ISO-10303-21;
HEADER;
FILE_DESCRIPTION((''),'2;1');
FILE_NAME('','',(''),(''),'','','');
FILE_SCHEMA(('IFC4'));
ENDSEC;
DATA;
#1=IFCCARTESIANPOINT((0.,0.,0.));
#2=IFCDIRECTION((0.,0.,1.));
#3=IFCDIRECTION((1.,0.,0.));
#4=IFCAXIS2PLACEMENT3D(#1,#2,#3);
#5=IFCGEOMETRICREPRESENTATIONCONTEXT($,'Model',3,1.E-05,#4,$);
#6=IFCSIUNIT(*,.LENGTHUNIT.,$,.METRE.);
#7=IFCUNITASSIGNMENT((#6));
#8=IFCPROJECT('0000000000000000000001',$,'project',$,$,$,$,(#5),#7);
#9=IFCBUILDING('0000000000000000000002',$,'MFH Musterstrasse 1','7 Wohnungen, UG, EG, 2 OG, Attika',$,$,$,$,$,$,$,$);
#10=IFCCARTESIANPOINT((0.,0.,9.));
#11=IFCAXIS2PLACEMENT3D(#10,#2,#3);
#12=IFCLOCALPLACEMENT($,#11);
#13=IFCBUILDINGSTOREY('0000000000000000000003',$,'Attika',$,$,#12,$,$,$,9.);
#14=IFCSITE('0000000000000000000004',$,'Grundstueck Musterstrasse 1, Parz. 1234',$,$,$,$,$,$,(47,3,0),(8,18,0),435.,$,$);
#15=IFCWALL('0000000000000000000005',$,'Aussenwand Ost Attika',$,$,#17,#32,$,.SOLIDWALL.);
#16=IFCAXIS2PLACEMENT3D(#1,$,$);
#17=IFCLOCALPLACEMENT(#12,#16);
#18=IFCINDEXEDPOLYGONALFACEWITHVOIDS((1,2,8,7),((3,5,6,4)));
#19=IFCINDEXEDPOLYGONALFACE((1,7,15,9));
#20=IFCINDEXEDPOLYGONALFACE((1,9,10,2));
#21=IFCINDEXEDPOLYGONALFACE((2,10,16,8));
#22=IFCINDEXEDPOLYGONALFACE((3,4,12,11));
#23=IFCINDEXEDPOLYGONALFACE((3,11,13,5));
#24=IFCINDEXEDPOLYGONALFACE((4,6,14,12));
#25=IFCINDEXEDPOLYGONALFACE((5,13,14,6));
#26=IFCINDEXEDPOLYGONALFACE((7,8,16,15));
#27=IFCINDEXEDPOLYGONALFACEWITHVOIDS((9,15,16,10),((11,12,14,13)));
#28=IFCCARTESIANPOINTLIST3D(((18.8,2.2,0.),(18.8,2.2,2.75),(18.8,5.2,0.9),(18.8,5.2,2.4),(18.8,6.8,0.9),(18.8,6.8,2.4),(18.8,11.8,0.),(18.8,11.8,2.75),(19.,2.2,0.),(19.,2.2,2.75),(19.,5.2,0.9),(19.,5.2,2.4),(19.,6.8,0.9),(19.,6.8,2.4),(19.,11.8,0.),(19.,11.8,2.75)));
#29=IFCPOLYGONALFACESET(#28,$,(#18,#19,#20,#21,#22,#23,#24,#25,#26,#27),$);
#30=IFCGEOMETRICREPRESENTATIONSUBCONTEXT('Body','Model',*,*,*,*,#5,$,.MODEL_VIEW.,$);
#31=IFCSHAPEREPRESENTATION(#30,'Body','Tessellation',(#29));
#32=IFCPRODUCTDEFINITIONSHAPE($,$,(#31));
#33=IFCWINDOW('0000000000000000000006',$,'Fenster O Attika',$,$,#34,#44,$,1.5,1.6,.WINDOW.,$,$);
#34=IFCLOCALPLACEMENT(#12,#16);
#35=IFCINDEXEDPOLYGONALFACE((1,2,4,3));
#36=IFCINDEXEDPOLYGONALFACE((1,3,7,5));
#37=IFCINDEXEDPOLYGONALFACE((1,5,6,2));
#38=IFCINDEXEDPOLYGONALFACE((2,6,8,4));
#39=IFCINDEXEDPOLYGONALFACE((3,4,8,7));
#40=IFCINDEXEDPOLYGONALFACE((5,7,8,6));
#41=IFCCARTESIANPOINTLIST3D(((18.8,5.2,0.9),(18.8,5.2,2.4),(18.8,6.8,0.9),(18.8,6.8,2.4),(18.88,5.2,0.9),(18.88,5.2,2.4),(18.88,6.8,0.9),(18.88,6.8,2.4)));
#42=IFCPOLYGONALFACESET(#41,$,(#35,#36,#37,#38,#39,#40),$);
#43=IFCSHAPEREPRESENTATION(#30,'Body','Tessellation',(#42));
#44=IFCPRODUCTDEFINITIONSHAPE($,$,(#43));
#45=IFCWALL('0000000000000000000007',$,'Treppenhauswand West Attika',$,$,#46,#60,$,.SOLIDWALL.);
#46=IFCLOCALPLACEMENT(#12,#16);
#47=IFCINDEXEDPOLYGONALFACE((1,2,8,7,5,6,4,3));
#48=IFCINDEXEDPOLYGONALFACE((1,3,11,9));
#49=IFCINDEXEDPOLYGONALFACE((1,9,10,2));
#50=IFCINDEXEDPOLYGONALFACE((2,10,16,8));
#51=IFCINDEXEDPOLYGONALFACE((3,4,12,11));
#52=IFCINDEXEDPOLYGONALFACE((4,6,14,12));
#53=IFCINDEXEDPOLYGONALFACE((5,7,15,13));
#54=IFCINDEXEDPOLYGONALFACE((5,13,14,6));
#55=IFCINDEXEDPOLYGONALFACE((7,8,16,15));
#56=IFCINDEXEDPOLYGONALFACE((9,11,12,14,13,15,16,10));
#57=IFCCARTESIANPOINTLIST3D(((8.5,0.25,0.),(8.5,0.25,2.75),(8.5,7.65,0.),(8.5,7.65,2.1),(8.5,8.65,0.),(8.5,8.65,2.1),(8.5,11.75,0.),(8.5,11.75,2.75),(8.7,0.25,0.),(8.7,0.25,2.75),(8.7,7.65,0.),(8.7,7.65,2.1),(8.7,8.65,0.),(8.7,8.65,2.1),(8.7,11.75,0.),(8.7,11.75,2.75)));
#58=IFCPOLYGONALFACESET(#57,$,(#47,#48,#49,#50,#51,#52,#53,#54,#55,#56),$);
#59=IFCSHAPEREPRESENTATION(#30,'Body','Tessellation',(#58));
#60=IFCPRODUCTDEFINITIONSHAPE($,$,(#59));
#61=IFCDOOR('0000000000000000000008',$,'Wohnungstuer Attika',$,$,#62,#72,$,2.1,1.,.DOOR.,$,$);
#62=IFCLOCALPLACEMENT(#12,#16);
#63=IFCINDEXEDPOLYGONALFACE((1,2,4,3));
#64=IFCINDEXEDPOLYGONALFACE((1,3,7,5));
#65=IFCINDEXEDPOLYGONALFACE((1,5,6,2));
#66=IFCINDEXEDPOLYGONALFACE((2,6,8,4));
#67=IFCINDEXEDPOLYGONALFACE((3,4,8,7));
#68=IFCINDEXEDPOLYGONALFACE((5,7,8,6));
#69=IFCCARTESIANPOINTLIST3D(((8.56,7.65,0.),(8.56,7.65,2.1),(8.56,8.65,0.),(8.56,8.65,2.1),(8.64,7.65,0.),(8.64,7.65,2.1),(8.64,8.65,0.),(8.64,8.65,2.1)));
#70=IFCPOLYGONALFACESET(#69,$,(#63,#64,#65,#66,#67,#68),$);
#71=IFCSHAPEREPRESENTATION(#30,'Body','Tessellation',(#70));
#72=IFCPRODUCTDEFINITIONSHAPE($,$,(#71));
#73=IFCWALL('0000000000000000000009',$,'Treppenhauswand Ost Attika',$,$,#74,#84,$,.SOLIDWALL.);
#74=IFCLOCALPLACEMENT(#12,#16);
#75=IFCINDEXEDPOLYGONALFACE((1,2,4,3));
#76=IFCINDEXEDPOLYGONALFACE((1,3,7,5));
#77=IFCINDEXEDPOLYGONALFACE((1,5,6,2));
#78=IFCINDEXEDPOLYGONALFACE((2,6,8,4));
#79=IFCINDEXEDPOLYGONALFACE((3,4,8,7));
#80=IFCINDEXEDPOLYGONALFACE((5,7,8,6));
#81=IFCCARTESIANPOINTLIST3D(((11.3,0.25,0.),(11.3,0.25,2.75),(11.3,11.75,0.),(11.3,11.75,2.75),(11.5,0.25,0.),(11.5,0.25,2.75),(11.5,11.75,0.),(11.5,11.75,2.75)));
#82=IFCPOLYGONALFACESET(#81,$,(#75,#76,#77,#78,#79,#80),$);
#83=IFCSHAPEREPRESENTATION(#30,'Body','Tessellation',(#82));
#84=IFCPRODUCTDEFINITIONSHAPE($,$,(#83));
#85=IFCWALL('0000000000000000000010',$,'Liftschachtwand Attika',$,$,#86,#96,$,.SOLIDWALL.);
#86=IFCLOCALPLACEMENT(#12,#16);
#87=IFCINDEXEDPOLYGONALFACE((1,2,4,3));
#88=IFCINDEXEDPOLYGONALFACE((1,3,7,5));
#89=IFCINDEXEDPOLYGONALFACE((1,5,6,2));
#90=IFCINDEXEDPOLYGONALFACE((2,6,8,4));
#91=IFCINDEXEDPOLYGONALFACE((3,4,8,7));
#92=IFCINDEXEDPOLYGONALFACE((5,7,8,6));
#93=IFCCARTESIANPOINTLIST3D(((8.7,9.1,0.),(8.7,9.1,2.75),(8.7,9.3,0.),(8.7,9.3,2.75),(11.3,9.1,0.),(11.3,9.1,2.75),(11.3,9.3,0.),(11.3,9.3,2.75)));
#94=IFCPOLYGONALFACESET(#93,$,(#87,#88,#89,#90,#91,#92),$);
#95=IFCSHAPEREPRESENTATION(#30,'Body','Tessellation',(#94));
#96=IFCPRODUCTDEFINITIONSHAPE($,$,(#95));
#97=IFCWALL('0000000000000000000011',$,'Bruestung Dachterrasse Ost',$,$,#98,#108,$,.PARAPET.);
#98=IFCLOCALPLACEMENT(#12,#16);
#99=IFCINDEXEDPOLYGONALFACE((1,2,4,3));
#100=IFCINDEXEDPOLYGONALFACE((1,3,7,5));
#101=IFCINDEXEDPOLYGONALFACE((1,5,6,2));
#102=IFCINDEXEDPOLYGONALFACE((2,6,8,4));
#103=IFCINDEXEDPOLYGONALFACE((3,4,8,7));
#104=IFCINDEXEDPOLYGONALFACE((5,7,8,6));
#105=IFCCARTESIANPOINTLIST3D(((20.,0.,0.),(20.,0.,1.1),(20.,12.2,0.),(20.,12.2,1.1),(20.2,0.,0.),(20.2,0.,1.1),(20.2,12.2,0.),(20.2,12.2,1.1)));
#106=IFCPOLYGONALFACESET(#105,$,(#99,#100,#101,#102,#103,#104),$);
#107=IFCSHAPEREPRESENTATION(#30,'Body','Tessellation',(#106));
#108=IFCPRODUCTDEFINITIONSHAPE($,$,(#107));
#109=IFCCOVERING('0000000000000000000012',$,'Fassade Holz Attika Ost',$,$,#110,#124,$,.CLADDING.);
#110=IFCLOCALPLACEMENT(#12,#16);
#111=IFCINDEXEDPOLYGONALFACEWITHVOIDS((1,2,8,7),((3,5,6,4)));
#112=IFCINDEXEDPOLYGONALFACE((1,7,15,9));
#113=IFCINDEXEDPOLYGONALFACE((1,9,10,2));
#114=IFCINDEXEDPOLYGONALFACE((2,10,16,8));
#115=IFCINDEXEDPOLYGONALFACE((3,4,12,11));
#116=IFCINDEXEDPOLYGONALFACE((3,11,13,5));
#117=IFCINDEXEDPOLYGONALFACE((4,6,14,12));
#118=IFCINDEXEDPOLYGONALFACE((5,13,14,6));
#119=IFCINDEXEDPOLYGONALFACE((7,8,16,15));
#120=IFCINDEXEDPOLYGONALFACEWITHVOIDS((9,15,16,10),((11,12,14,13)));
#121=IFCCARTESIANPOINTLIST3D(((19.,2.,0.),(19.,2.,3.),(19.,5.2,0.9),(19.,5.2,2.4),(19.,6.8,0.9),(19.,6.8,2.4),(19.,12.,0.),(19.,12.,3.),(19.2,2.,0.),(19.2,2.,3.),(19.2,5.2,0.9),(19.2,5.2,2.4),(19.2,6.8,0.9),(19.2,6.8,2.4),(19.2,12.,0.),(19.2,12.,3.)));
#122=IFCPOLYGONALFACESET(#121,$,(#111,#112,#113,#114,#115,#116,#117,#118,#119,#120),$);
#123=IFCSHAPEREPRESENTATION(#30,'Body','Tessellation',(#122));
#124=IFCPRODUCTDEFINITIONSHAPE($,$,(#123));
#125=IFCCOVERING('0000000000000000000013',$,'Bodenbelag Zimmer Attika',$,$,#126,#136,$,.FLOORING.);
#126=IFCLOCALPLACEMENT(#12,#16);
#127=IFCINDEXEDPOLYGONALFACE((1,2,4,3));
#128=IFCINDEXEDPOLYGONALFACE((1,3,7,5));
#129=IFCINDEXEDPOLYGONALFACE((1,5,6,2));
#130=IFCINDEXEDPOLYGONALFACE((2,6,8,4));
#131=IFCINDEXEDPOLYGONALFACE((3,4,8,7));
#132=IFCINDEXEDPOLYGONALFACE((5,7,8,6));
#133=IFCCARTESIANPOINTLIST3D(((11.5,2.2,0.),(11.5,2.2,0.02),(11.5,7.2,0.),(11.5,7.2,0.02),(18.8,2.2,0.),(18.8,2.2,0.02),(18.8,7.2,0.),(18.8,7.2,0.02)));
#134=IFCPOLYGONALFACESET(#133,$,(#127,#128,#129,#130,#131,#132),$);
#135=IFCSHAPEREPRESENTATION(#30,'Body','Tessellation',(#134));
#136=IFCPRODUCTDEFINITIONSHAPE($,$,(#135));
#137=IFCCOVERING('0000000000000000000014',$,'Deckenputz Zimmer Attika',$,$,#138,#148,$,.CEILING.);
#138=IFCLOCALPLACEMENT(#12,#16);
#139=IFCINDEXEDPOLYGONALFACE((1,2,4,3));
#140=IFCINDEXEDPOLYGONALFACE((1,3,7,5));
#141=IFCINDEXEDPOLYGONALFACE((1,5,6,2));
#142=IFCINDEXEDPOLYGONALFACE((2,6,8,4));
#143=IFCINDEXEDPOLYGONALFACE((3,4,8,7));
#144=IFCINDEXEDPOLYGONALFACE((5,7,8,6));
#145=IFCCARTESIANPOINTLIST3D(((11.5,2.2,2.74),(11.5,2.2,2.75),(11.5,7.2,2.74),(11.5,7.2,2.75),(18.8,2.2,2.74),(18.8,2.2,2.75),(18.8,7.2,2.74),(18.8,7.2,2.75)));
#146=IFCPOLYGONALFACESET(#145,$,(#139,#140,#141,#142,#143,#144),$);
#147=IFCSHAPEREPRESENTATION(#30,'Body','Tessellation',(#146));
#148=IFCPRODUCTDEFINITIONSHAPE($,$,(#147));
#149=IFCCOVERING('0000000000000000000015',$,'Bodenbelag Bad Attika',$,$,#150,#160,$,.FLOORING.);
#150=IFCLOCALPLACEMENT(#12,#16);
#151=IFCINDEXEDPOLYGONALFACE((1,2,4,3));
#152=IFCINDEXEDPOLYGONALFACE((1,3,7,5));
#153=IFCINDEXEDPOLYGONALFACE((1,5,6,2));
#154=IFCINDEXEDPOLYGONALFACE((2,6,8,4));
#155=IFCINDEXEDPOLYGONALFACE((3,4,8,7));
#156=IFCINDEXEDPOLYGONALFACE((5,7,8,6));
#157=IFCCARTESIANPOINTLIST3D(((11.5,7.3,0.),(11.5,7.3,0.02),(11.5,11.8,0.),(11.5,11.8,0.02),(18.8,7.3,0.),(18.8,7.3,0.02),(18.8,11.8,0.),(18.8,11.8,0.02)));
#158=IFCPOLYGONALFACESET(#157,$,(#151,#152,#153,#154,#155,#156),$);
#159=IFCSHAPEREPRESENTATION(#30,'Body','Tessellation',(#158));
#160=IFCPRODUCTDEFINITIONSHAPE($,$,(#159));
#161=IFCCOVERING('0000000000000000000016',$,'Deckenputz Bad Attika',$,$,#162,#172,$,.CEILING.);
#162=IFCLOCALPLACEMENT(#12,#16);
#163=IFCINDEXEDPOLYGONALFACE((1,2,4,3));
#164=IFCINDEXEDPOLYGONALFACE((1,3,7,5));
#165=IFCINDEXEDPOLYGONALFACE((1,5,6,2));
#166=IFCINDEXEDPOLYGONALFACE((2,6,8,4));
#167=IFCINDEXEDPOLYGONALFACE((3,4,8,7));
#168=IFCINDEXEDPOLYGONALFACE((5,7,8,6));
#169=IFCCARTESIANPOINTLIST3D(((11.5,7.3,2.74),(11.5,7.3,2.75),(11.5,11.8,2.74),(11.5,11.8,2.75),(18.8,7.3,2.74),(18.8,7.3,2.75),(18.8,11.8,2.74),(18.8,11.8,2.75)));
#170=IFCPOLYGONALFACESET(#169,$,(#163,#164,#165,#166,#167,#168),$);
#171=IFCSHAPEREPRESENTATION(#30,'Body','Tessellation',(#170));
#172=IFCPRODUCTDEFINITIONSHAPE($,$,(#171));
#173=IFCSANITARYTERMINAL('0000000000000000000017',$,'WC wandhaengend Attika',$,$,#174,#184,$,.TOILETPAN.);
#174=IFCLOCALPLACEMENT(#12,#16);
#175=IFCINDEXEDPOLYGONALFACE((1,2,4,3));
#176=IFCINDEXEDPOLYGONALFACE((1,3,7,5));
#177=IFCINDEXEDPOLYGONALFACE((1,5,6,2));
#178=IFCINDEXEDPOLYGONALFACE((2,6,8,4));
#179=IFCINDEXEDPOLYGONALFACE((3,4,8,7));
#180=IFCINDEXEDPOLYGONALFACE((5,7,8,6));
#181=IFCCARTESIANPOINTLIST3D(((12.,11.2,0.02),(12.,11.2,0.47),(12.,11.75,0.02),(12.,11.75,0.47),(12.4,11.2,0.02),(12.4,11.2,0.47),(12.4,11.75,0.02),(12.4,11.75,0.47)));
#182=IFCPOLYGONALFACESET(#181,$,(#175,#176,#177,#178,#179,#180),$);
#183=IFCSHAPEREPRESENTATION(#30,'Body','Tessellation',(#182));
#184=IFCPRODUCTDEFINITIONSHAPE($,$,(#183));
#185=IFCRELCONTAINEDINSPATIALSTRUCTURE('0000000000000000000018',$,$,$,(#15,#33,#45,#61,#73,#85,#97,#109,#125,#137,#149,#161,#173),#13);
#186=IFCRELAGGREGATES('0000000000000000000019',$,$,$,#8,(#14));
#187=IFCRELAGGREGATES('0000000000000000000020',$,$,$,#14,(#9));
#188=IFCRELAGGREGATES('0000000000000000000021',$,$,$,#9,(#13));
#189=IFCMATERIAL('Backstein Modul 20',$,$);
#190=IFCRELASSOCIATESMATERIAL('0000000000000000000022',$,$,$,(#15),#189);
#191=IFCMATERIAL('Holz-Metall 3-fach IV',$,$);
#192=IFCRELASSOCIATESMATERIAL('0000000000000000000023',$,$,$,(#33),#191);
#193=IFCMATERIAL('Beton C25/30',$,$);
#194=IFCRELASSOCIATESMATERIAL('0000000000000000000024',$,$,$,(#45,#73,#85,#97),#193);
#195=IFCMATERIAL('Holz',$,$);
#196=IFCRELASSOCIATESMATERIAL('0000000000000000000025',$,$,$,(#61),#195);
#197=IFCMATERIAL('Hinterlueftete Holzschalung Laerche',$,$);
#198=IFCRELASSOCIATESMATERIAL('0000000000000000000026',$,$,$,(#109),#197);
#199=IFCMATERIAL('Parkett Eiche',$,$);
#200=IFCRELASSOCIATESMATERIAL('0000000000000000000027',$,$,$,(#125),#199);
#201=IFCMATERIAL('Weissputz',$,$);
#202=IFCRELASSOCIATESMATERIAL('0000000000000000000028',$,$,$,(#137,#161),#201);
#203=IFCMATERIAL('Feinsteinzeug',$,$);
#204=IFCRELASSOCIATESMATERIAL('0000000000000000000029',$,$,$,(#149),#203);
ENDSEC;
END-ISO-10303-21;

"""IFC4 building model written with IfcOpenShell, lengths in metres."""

from ifc_helpers import new_model, si_unit, frame, frame_2d, origin_with_axes, place, context, subcontext, project, spatial, rectangle, extrude, material, element, fill, save


model = new_model("IFC4")

# Units and contexts
model_context = context("Model", 3, precision=1e-05, world=origin_with_axes())
body_context = subcontext(model_context, "Body", "Model", "MODEL_VIEW")
ifc_project = project(units=[si_unit("LENGTHUNIT", "METRE")], contexts=[model_context])

# Site, building, storey
site = spatial("IfcSite", under=ifc_project, Name="Grundstueck Musterstrasse 1, Parz. 1234", RefLatitude=(47, 3, 0), RefLongitude=(8, 18, 0), RefElevation=435.0)
building = spatial("IfcBuilding", under=site, Name="MFH Musterstrasse 1", Description="7 Wohnungen, UG, EG, 2 OG, Attika")
storey_placement = place(None, frame((0.0, 0.0, 9.0), z_axis=(0.0, 0.0, 1.0), x_axis=(1.0, 0.0, 0.0)))
storey = spatial("IfcBuildingStorey", under=building, at=storey_placement, Name="Attika", Elevation=9.0)

# Wall, opening, window
ifc_material_1 = material(Name="Backstein Modul 20")
wall_1_placement = place(storey_placement, frame((18.8, 2.2, 0.0), z_axis=(0.0, 0.0, 1.0), x_axis=(1.0, 0.0, 0.0)))
wall_1 = element("IfcWall", 1, at=wall_1_placement, inside=storey, material=ifc_material_1, Name="Aussenwand Ost Attika", PredefinedType="SOLIDWALL", context=body_context, shape_type="SweptSolid", body=[
    extrude(rectangle(XDim=0.2, YDim=9.6, at=frame_2d((0.1, 4.8))), origin_with_axes(), (0.0, 0.0, 1.0), 2.75),
])
opening_1_placement = place(wall_1_placement, frame((-0.01, 3.0, 0.9), z_axis=(0.0, 0.0, 1.0), x_axis=(1.0, 0.0, 0.0)))
opening_1 = element("IfcOpeningElement", 2, at=opening_1_placement, cuts=wall_1, context=body_context, shape_type="SweptSolid", body=[
    extrude(rectangle(XDim=0.42, YDim=1.6, at=frame_2d((0.21, 0.8))), origin_with_axes(), (0.0, 0.0, 1.0), 1.5),
])
ifc_material_2 = material(Name="Holz-Metall 3-fach IV")
window_placement = place(storey_placement, frame((18.8, 5.2, 0.9), z_axis=(0.0, 0.0, 1.0), x_axis=(1.0, 0.0, 0.0)))
window = element("IfcWindow", 3, at=window_placement, inside=storey, material=ifc_material_2, Name="Fenster O Attika", OverallHeight=1.5, OverallWidth=1.6, PredefinedType="WINDOW", context=body_context, shape_type="SweptSolid", body=[
    extrude(rectangle(XDim=0.08, YDim=1.6, at=frame_2d((0.04, 0.8))), origin_with_axes(), (0.0, 0.0, 1.0), 1.5),
])
fill(opening_1, window)

# Wall, opening, door
ifc_material_3 = material(Name="Beton C25/30")
wall_2_placement = place(storey_placement, frame((8.5, 0.25, 0.0), z_axis=(0.0, 0.0, 1.0), x_axis=(1.0, 0.0, 0.0)))
wall_2 = element("IfcWall", 4, at=wall_2_placement, inside=storey, material=ifc_material_3, Name="Treppenhauswand West Attika", PredefinedType="SOLIDWALL", context=body_context, shape_type="SweptSolid", body=[
    extrude(rectangle(XDim=0.2, YDim=11.5, at=frame_2d((0.1, 5.75))), origin_with_axes(), (0.0, 0.0, 1.0), 2.75),
])
opening_2_placement = place(wall_2_placement, frame((-0.01, 7.4, 0.0), z_axis=(0.0, 0.0, 1.0), x_axis=(1.0, 0.0, 0.0)))
opening_2 = element("IfcOpeningElement", 5, at=opening_2_placement, cuts=wall_2, context=body_context, shape_type="SweptSolid", body=[
    extrude(rectangle(XDim=0.22, YDim=1.0, at=frame_2d((0.11, 0.5))), origin_with_axes(), (0.0, 0.0, 1.0), 2.1),
])
ifc_material_4 = material(Name="Holz")
door_placement = place(storey_placement, frame((8.56, 7.65, 0.0), z_axis=(0.0, 0.0, 1.0), x_axis=(1.0, 0.0, 0.0)))
door = element("IfcDoor", 6, at=door_placement, inside=storey, material=ifc_material_4, Name="Wohnungstuer Attika", OverallHeight=2.1, OverallWidth=1.0, PredefinedType="DOOR", context=body_context, shape_type="SweptSolid", body=[
    extrude(rectangle(XDim=0.08, YDim=1.0, at=frame_2d((0.04, 0.5))), origin_with_axes(), (0.0, 0.0, 1.0), 2.1),
])
fill(opening_2, door)

# Walls
wall_3_placement = place(storey_placement, frame((11.3, 0.25, 0.0), z_axis=(0.0, 0.0, 1.0), x_axis=(1.0, 0.0, 0.0)))
element("IfcWall", 7, at=wall_3_placement, inside=storey, material=ifc_material_3, Name="Treppenhauswand Ost Attika", PredefinedType="SOLIDWALL", context=body_context, shape_type="SweptSolid", body=[
    extrude(rectangle(XDim=0.2, YDim=11.5, at=frame_2d((0.1, 5.75))), origin_with_axes(), (0.0, 0.0, 1.0), 2.75),
])
wall_4_placement = place(storey_placement, frame((8.7, 9.1, 0.0), z_axis=(0.0, 0.0, 1.0), x_axis=(1.0, 0.0, 0.0)))
element("IfcWall", 8, at=wall_4_placement, inside=storey, material=ifc_material_3, Name="Liftschachtwand Attika", PredefinedType="SOLIDWALL", context=body_context, shape_type="SweptSolid", body=[
    extrude(rectangle(XDim=2.6, YDim=0.2, at=frame_2d((1.3, 0.1))), origin_with_axes(), (0.0, 0.0, 1.0), 2.75),
])
wall_5_placement = place(storey_placement, frame((20.0, 0.0, 0.0), z_axis=(0.0, 0.0, 1.0), x_axis=(1.0, 0.0, 0.0)))
element("IfcWall", 9, at=wall_5_placement, inside=storey, material=ifc_material_3, Name="Bruestung Dachterrasse Ost", PredefinedType="PARAPET", context=body_context, shape_type="SweptSolid", body=[
    extrude(rectangle(XDim=0.2, YDim=12.2, at=frame_2d((0.1, 6.1))), origin_with_axes(), (0.0, 0.0, 1.0), 1.1),
])

# Covering, opening
ifc_material_5 = material(Name="Hinterlueftete Holzschalung Laerche")
covering_1_placement = place(storey_placement, frame((19.0, 2.0, 0.0), z_axis=(0.0, 0.0, 1.0), x_axis=(1.0, 0.0, 0.0)))
covering_1 = element("IfcCovering", 10, at=covering_1_placement, inside=storey, material=ifc_material_5, Name="Fassade Holz Attika Ost", PredefinedType="CLADDING", context=body_context, shape_type="SweptSolid", body=[
    extrude(rectangle(XDim=0.2, YDim=10.0, at=frame_2d((0.1, 5.0))), origin_with_axes(), (0.0, 0.0, 1.0), 3.0),
])
opening_3_placement = place(covering_1_placement, frame((-0.21, 3.2, 0.9), z_axis=(0.0, 0.0, 1.0), x_axis=(1.0, 0.0, 0.0)))
element("IfcOpeningElement", 11, at=opening_3_placement, cuts=covering_1, context=body_context, shape_type="SweptSolid", body=[
    extrude(rectangle(XDim=0.42, YDim=1.6, at=frame_2d((0.21, 0.8))), origin_with_axes(), (0.0, 0.0, 1.0), 1.5),
])

# Coverings
ifc_material_6 = material(Name="Parkett Eiche")
covering_2_placement = place(storey_placement, frame((11.5, 2.2, 0.0), z_axis=(0.0, 0.0, 1.0), x_axis=(1.0, 0.0, 0.0)))
element("IfcCovering", 12, at=covering_2_placement, inside=storey, material=ifc_material_6, Name="Bodenbelag Zimmer Attika", PredefinedType="FLOORING", context=body_context, shape_type="SweptSolid", body=[
    extrude(rectangle(XDim=7.3, YDim=5.0, at=frame_2d((3.65, 2.5))), origin_with_axes(), (0.0, 0.0, 1.0), 0.02),
])
ifc_material_7 = material(Name="Weissputz")
covering_3_placement = place(storey_placement, frame((11.5, 2.2, 2.74), z_axis=(0.0, 0.0, 1.0), x_axis=(1.0, 0.0, 0.0)))
element("IfcCovering", 13, at=covering_3_placement, inside=storey, material=ifc_material_7, Name="Deckenputz Zimmer Attika", PredefinedType="CEILING", context=body_context, shape_type="SweptSolid", body=[
    extrude(rectangle(XDim=7.3, YDim=5.0, at=frame_2d((3.65, 2.5))), origin_with_axes(), (0.0, 0.0, 1.0), 0.01),
])
ifc_material_8 = material(Name="Feinsteinzeug")
covering_4_placement = place(storey_placement, frame((11.5, 7.3, 0.0), z_axis=(0.0, 0.0, 1.0), x_axis=(1.0, 0.0, 0.0)))
element("IfcCovering", 14, at=covering_4_placement, inside=storey, material=ifc_material_8, Name="Bodenbelag Bad Attika", PredefinedType="FLOORING", context=body_context, shape_type="SweptSolid", body=[
    extrude(rectangle(XDim=7.3, YDim=4.5, at=frame_2d((3.65, 2.25))), origin_with_axes(), (0.0, 0.0, 1.0), 0.02),
])
covering_5_placement = place(storey_placement, frame((11.5, 7.3, 2.74), z_axis=(0.0, 0.0, 1.0), x_axis=(1.0, 0.0, 0.0)))
element("IfcCovering", 15, at=covering_5_placement, inside=storey, material=ifc_material_7, Name="Deckenputz Bad Attika", PredefinedType="CEILING", context=body_context, shape_type="SweptSolid", body=[
    extrude(rectangle(XDim=7.3, YDim=4.5, at=frame_2d((3.65, 2.25))), origin_with_axes(), (0.0, 0.0, 1.0), 0.01),
])

# Sanitary terminal
sanitary_terminal_1_placement = place(storey_placement, frame((12.0, 11.2, 0.02), z_axis=(0.0, 0.0, 1.0), x_axis=(1.0, 0.0, 0.0)))
element("IfcSanitaryTerminal", 16, at=sanitary_terminal_1_placement, inside=storey, Name="WC wandhaengend Attika", PredefinedType="TOILETPAN", context=body_context, shape_type="SweptSolid", body=[
    extrude(rectangle(XDim=0.4, YDim=0.55, at=frame_2d((0.2, 0.275))), origin_with_axes(), (0.0, 0.0, 1.0), 0.45),
])

save(model, "model.ifc")
